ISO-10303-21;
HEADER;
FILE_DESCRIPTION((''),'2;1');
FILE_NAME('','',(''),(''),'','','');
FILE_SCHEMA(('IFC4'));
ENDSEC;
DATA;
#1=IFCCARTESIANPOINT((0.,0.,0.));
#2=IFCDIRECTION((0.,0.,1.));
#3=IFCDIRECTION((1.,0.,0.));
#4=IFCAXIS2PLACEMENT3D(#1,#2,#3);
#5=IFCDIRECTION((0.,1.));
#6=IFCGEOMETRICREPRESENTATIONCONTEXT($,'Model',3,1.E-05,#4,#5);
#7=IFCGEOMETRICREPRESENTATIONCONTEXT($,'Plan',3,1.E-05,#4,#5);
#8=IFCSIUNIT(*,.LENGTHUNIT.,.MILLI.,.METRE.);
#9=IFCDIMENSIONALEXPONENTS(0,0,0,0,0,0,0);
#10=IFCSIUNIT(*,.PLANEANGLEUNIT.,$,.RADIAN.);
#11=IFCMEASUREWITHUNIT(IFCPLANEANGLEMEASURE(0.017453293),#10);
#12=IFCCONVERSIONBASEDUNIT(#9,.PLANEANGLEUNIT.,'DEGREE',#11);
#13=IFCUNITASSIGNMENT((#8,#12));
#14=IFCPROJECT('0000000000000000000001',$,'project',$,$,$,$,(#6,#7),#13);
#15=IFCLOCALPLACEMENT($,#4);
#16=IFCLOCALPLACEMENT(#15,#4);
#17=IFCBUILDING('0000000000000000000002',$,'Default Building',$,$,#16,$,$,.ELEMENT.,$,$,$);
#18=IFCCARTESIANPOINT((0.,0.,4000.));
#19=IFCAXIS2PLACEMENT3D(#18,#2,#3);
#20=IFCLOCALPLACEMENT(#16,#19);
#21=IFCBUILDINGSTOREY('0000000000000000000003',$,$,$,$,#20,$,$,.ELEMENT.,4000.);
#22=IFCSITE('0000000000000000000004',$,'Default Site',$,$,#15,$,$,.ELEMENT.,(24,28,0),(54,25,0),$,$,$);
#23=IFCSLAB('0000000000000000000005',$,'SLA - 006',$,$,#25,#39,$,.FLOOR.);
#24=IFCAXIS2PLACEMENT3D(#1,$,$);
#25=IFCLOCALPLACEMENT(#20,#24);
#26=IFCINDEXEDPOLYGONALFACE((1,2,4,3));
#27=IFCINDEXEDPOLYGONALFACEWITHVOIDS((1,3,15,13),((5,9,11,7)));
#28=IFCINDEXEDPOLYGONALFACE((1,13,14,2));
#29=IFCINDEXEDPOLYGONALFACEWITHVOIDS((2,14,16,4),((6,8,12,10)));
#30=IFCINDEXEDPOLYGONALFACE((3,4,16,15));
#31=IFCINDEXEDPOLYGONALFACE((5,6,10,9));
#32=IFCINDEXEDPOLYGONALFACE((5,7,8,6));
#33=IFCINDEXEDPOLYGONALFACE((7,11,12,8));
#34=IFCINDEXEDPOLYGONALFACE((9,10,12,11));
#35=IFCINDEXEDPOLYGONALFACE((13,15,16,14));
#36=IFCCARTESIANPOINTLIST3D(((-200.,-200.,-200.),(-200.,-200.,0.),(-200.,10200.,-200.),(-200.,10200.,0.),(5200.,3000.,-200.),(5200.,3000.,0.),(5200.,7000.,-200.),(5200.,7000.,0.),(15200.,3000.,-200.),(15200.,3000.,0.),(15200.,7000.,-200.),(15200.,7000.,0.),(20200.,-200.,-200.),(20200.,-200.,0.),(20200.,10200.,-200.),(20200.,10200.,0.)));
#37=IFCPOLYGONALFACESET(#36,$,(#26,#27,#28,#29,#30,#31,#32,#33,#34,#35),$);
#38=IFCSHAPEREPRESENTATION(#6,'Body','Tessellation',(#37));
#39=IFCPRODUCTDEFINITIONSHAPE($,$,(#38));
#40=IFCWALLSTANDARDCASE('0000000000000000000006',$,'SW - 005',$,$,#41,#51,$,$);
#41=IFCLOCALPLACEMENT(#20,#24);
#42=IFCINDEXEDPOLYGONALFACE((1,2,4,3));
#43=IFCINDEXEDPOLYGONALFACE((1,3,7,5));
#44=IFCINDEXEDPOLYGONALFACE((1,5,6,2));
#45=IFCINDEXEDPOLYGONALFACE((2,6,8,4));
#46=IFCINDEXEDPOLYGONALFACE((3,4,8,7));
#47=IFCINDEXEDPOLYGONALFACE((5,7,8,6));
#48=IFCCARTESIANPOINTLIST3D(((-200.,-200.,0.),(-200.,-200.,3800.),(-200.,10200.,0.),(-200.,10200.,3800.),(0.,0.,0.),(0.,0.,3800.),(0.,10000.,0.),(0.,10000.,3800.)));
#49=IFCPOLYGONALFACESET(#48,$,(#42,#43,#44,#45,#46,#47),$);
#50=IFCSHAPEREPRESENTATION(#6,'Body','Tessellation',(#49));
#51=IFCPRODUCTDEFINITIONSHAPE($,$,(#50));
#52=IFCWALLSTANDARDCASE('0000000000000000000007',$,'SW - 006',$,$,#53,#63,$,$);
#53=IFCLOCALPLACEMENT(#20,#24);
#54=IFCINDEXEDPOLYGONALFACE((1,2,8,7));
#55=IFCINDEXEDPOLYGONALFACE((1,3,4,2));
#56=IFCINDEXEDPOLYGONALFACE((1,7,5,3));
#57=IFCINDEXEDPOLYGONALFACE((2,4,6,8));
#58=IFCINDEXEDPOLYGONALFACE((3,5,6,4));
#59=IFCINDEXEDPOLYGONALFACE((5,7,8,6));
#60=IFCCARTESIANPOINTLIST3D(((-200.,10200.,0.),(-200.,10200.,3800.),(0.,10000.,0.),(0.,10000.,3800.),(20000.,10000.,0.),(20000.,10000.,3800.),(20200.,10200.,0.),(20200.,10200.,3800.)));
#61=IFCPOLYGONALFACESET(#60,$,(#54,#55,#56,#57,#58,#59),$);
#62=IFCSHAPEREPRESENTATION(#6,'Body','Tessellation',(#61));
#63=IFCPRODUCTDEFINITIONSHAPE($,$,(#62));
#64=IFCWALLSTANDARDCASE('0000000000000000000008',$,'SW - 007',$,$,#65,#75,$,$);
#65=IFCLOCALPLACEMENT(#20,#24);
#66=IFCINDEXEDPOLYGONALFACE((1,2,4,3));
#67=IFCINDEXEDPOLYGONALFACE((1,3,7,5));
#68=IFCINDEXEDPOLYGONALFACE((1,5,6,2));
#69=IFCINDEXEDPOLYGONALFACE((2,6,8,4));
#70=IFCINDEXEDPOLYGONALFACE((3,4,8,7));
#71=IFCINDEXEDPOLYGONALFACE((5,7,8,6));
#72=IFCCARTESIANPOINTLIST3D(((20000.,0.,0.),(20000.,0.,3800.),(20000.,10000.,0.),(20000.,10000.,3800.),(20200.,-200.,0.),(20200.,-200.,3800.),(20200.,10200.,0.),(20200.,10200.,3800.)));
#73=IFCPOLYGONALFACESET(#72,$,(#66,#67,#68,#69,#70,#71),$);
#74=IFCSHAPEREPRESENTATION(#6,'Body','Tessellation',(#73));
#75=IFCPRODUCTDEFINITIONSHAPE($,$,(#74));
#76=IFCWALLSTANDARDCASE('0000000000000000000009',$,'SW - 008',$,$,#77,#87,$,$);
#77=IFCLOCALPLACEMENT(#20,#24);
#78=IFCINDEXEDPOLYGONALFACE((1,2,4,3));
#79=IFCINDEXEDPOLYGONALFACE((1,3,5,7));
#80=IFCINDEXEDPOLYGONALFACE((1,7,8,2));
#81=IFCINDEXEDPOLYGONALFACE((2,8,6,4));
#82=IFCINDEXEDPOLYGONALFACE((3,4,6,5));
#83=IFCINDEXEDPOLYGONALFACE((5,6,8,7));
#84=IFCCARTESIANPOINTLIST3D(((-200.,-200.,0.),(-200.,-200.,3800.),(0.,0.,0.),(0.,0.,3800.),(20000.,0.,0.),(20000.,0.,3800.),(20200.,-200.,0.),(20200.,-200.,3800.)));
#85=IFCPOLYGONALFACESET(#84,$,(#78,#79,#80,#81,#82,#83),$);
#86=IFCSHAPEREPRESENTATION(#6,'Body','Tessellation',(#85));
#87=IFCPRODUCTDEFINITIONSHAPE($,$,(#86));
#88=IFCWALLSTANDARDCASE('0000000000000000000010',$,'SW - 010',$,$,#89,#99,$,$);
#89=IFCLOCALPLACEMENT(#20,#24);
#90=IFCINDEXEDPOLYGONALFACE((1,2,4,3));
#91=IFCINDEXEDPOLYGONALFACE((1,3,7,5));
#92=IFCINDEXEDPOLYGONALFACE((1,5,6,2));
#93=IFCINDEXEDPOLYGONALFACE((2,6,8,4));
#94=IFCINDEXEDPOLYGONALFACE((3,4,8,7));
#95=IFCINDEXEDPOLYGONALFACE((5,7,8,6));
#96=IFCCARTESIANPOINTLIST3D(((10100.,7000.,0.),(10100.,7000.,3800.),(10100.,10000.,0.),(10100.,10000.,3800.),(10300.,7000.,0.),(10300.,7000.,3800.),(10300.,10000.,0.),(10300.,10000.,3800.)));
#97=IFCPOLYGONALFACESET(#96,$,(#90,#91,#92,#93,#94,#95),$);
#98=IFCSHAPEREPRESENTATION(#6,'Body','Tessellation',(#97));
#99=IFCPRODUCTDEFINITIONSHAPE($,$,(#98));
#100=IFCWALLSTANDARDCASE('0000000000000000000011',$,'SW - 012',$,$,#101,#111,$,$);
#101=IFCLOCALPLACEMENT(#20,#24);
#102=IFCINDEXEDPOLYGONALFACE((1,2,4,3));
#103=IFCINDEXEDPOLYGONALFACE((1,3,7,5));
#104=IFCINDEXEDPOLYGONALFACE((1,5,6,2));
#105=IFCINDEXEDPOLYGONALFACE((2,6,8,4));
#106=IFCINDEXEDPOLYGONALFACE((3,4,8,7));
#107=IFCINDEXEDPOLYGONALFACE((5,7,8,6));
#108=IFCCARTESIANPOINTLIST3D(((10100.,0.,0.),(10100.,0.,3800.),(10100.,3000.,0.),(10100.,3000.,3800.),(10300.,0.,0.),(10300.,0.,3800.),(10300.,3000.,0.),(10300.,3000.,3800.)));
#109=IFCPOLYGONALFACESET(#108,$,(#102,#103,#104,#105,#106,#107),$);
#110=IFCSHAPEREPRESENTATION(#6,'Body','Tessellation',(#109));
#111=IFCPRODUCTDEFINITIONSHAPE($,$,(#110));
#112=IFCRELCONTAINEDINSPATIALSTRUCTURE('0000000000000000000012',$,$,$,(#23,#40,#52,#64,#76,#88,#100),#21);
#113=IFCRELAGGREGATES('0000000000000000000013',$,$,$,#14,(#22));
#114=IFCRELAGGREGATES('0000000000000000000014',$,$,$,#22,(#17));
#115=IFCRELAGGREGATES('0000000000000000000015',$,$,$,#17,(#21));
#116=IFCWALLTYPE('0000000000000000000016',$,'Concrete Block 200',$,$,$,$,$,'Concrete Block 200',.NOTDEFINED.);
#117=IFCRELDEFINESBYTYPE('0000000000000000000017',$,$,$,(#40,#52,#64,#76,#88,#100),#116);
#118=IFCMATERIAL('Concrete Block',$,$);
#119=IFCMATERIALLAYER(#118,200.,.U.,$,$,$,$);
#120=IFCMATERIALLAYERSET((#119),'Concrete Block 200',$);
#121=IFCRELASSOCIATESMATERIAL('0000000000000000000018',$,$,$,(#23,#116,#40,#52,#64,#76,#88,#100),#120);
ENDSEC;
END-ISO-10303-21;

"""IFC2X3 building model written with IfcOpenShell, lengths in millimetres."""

from ifc_helpers import new_model, entity, si_unit, converted_unit, direction, frame, origin_with_axes, place, context, project, spatial, polyline, outline, extrude, material, layer, layer_set, layer_usage, type_object, element, save


model = new_model("IFC2X3")

# Units and contexts
model_context = context("Model", 3, precision=1e-05, world=origin_with_axes(), true_north=direction((0.0, 1.0)))
plan_context = context("Plan", 3, precision=1e-05, world=origin_with_axes(), true_north=direction((0.0, 1.0)))
ifc_project = project(units=[si_unit("LENGTHUNIT", "METRE", prefix="MILLI"), converted_unit("PLANEANGLEUNIT", "DEGREE", entity("IfcPlaneAngleMeasure", 0.017453293), si_unit("PLANEANGLEUNIT", "RADIAN"), dimensions=[0, 0, 0, 0, 0, 0, 0])], contexts=[model_context, plan_context])

# Site, building, storey
site_placement = place(None, origin_with_axes())
site = spatial("IfcSite", under=ifc_project, at=site_placement, Name="Default Site", CompositionType="ELEMENT", RefLatitude=(24, 28, 0), RefLongitude=(54, 25, 0))
building_placement = place(site_placement, origin_with_axes())
building = spatial("IfcBuilding", under=site, at=building_placement, Name="Default Building", CompositionType="ELEMENT")
storey_placement = place(building_placement, frame((0.0, 0.0, 4000.0), z_axis=(0.0, 0.0, 1.0), x_axis=(1.0, 0.0, 0.0)))
storey = spatial("IfcBuildingStorey", under=building, at=storey_placement, CompositionType="ELEMENT", Elevation=4000.0)

# Slab, opening
ifc_material = material(Name="Concrete Block")
ifc_layer = layer(ifc_material, 200.0, ventilated="UNKNOWN")
ifc_layer_set = layer_set([ifc_layer], Name="Concrete Block 200")
ifc_layer_usage_1 = layer_usage(ifc_layer_set, "AXIS3", "NEGATIVE", 200.0)
slab_placement = place(storey_placement, frame((-200.0, -200.0, -200.0), z_axis=(0.0, 0.0, 1.0), x_axis=(1.0, 0.0, 0.0)))
slab = element("IfcSlab", 1, at=slab_placement, inside=storey, material=ifc_layer_usage_1, Name="SLA - 006", PredefinedType="FLOOR", context=model_context, shape_type="SweptSolid", body=[
    extrude(outline(polyline([(0.0, 0.0), (20400.0, 0.0), (20400.0, 10400.0), (0.0, 10400.0), (0.0, 0.0)])), origin_with_axes(), (0.0, 0.0, 1.0), 200.0),
])
opening_placement = place(slab_placement, origin_with_axes())
element("IfcOpeningElement", 2, at=opening_placement, cuts=slab, context=model_context, shape_type="SweptSolid", body=[
    extrude(outline(polyline([(15400.0, 3200.0), (5400.0, 3200.0), (5400.0, 7200.0), (15400.0, 7200.0), (15400.0, 3200.0)])), origin_with_axes(), (0.0, 0.0, 1.0), 200.0),
])

# Walls
ifc_layer_usage_2 = layer_usage(ifc_layer_set, "AXIS2", "POSITIVE", 0.0)
wall_type = type_object("IfcWallType", Name="Concrete Block 200", ElementType="Concrete Block 200", PredefinedType="NOTDEFINED", material=ifc_layer_set)
wall_1_placement = place(storey_placement, frame((0.0, 0.0, 0.0), z_axis=(0.0, 0.0, 1.0), x_axis=(0.0, 1.0, 0.0)))
element("IfcWallStandardCase", 3, at=wall_1_placement, inside=storey, type_object=wall_type, material=ifc_layer_usage_2, Name="SW - 005", context=model_context, shape_type="SweptSolid", body=[
    extrude(outline(polyline([(0.0, 0.0), (10000.0, 0.0), (10200.0, 200.0), (-200.0, 200.0), (0.0, 0.0)])), origin_with_axes(), (0.0, 0.0, 1.0), 3800.0),
])
ifc_layer_usage_3 = layer_usage(ifc_layer_set, "AXIS2", "POSITIVE", 0.0)
wall_2_placement = place(storey_placement, frame((0.0, 10000.0, 0.0), z_axis=(0.0, 0.0, 1.0), x_axis=(1.0, 0.0, 0.0)))
element("IfcWallStandardCase", 4, at=wall_2_placement, inside=storey, type_object=wall_type, material=ifc_layer_usage_3, Name="SW - 006", context=model_context, shape_type="SweptSolid", body=[
    extrude(outline(polyline([(0.0, 0.0), (20000.0, 0.0), (20200.0, 200.0), (-200.0, 200.0), (0.0, 0.0)])), origin_with_axes(), (0.0, 0.0, 1.0), 3800.0),
])
ifc_layer_usage_4 = layer_usage(ifc_layer_set, "AXIS2", "POSITIVE", 0.0)
wall_3_placement = place(storey_placement, frame((20000.0, 10000.0, 0.0), z_axis=(0.0, 0.0, 1.0), x_axis=(0.0, -1.0, 0.0)))
element("IfcWallStandardCase", 5, at=wall_3_placement, inside=storey, type_object=wall_type, material=ifc_layer_usage_4, Name="SW - 007", context=model_context, shape_type="SweptSolid", body=[
    extrude(outline(polyline([(0.0, 0.0), (10000.0, 0.0), (10200.0, 200.0), (-200.0, 200.0), (0.0, 0.0)])), origin_with_axes(), (0.0, 0.0, 1.0), 3800.0),
])
ifc_layer_usage_5 = layer_usage(ifc_layer_set, "AXIS2", "POSITIVE", 0.0)
wall_4_placement = place(storey_placement, frame((20000.0, 0.0, 0.0), z_axis=(0.0, 0.0, 1.0), x_axis=(-1.0, 0.0, 0.0)))
element("IfcWallStandardCase", 6, at=wall_4_placement, inside=storey, type_object=wall_type, material=ifc_layer_usage_5, Name="SW - 008", context=model_context, shape_type="SweptSolid", body=[
    extrude(outline(polyline([(0.0, 0.0), (20000.0, 0.0), (20200.0, 200.0), (-200.0, 200.0), (0.0, 0.0)])), origin_with_axes(), (0.0, 0.0, 1.0), 3800.0),
])
ifc_layer_usage_6 = layer_usage(ifc_layer_set, "AXIS2", "NEGATIVE", 100.0)
wall_5_placement = place(storey_placement, frame((10200.0, 7000.0, 0.0), z_axis=(0.0, 0.0, 1.0), x_axis=(0.0, 1.0, 0.0)))
element("IfcWallStandardCase", 7, at=wall_5_placement, inside=storey, type_object=wall_type, material=ifc_layer_usage_6, Name="SW - 010", context=model_context, shape_type="SweptSolid", body=[
    extrude(outline(polyline([(0.0, -100.0), (3000.0, -100.0), (3000.0, 100.0), (0.0, 100.0), (0.0, -100.0)])), origin_with_axes(), (0.0, 0.0, 1.0), 3800.0),
])
ifc_layer_usage_7 = layer_usage(ifc_layer_set, "AXIS2", "NEGATIVE", 100.0)
wall_6_placement = place(storey_placement, frame((10200.0, 3000.0, 0.0), z_axis=(0.0, 0.0, 1.0), x_axis=(0.0, -1.0, 0.0)))
element("IfcWallStandardCase", 8, at=wall_6_placement, inside=storey, type_object=wall_type, material=ifc_layer_usage_7, Name="SW - 012", context=model_context, shape_type="SweptSolid", body=[
    extrude(outline(polyline([(0.0, -100.0), (3000.0, -100.0), (3000.0, 100.0), (0.0, 100.0), (0.0, -100.0)])), origin_with_axes(), (0.0, 0.0, 1.0), 3800.0),
])

save(model, "model.ifc")
